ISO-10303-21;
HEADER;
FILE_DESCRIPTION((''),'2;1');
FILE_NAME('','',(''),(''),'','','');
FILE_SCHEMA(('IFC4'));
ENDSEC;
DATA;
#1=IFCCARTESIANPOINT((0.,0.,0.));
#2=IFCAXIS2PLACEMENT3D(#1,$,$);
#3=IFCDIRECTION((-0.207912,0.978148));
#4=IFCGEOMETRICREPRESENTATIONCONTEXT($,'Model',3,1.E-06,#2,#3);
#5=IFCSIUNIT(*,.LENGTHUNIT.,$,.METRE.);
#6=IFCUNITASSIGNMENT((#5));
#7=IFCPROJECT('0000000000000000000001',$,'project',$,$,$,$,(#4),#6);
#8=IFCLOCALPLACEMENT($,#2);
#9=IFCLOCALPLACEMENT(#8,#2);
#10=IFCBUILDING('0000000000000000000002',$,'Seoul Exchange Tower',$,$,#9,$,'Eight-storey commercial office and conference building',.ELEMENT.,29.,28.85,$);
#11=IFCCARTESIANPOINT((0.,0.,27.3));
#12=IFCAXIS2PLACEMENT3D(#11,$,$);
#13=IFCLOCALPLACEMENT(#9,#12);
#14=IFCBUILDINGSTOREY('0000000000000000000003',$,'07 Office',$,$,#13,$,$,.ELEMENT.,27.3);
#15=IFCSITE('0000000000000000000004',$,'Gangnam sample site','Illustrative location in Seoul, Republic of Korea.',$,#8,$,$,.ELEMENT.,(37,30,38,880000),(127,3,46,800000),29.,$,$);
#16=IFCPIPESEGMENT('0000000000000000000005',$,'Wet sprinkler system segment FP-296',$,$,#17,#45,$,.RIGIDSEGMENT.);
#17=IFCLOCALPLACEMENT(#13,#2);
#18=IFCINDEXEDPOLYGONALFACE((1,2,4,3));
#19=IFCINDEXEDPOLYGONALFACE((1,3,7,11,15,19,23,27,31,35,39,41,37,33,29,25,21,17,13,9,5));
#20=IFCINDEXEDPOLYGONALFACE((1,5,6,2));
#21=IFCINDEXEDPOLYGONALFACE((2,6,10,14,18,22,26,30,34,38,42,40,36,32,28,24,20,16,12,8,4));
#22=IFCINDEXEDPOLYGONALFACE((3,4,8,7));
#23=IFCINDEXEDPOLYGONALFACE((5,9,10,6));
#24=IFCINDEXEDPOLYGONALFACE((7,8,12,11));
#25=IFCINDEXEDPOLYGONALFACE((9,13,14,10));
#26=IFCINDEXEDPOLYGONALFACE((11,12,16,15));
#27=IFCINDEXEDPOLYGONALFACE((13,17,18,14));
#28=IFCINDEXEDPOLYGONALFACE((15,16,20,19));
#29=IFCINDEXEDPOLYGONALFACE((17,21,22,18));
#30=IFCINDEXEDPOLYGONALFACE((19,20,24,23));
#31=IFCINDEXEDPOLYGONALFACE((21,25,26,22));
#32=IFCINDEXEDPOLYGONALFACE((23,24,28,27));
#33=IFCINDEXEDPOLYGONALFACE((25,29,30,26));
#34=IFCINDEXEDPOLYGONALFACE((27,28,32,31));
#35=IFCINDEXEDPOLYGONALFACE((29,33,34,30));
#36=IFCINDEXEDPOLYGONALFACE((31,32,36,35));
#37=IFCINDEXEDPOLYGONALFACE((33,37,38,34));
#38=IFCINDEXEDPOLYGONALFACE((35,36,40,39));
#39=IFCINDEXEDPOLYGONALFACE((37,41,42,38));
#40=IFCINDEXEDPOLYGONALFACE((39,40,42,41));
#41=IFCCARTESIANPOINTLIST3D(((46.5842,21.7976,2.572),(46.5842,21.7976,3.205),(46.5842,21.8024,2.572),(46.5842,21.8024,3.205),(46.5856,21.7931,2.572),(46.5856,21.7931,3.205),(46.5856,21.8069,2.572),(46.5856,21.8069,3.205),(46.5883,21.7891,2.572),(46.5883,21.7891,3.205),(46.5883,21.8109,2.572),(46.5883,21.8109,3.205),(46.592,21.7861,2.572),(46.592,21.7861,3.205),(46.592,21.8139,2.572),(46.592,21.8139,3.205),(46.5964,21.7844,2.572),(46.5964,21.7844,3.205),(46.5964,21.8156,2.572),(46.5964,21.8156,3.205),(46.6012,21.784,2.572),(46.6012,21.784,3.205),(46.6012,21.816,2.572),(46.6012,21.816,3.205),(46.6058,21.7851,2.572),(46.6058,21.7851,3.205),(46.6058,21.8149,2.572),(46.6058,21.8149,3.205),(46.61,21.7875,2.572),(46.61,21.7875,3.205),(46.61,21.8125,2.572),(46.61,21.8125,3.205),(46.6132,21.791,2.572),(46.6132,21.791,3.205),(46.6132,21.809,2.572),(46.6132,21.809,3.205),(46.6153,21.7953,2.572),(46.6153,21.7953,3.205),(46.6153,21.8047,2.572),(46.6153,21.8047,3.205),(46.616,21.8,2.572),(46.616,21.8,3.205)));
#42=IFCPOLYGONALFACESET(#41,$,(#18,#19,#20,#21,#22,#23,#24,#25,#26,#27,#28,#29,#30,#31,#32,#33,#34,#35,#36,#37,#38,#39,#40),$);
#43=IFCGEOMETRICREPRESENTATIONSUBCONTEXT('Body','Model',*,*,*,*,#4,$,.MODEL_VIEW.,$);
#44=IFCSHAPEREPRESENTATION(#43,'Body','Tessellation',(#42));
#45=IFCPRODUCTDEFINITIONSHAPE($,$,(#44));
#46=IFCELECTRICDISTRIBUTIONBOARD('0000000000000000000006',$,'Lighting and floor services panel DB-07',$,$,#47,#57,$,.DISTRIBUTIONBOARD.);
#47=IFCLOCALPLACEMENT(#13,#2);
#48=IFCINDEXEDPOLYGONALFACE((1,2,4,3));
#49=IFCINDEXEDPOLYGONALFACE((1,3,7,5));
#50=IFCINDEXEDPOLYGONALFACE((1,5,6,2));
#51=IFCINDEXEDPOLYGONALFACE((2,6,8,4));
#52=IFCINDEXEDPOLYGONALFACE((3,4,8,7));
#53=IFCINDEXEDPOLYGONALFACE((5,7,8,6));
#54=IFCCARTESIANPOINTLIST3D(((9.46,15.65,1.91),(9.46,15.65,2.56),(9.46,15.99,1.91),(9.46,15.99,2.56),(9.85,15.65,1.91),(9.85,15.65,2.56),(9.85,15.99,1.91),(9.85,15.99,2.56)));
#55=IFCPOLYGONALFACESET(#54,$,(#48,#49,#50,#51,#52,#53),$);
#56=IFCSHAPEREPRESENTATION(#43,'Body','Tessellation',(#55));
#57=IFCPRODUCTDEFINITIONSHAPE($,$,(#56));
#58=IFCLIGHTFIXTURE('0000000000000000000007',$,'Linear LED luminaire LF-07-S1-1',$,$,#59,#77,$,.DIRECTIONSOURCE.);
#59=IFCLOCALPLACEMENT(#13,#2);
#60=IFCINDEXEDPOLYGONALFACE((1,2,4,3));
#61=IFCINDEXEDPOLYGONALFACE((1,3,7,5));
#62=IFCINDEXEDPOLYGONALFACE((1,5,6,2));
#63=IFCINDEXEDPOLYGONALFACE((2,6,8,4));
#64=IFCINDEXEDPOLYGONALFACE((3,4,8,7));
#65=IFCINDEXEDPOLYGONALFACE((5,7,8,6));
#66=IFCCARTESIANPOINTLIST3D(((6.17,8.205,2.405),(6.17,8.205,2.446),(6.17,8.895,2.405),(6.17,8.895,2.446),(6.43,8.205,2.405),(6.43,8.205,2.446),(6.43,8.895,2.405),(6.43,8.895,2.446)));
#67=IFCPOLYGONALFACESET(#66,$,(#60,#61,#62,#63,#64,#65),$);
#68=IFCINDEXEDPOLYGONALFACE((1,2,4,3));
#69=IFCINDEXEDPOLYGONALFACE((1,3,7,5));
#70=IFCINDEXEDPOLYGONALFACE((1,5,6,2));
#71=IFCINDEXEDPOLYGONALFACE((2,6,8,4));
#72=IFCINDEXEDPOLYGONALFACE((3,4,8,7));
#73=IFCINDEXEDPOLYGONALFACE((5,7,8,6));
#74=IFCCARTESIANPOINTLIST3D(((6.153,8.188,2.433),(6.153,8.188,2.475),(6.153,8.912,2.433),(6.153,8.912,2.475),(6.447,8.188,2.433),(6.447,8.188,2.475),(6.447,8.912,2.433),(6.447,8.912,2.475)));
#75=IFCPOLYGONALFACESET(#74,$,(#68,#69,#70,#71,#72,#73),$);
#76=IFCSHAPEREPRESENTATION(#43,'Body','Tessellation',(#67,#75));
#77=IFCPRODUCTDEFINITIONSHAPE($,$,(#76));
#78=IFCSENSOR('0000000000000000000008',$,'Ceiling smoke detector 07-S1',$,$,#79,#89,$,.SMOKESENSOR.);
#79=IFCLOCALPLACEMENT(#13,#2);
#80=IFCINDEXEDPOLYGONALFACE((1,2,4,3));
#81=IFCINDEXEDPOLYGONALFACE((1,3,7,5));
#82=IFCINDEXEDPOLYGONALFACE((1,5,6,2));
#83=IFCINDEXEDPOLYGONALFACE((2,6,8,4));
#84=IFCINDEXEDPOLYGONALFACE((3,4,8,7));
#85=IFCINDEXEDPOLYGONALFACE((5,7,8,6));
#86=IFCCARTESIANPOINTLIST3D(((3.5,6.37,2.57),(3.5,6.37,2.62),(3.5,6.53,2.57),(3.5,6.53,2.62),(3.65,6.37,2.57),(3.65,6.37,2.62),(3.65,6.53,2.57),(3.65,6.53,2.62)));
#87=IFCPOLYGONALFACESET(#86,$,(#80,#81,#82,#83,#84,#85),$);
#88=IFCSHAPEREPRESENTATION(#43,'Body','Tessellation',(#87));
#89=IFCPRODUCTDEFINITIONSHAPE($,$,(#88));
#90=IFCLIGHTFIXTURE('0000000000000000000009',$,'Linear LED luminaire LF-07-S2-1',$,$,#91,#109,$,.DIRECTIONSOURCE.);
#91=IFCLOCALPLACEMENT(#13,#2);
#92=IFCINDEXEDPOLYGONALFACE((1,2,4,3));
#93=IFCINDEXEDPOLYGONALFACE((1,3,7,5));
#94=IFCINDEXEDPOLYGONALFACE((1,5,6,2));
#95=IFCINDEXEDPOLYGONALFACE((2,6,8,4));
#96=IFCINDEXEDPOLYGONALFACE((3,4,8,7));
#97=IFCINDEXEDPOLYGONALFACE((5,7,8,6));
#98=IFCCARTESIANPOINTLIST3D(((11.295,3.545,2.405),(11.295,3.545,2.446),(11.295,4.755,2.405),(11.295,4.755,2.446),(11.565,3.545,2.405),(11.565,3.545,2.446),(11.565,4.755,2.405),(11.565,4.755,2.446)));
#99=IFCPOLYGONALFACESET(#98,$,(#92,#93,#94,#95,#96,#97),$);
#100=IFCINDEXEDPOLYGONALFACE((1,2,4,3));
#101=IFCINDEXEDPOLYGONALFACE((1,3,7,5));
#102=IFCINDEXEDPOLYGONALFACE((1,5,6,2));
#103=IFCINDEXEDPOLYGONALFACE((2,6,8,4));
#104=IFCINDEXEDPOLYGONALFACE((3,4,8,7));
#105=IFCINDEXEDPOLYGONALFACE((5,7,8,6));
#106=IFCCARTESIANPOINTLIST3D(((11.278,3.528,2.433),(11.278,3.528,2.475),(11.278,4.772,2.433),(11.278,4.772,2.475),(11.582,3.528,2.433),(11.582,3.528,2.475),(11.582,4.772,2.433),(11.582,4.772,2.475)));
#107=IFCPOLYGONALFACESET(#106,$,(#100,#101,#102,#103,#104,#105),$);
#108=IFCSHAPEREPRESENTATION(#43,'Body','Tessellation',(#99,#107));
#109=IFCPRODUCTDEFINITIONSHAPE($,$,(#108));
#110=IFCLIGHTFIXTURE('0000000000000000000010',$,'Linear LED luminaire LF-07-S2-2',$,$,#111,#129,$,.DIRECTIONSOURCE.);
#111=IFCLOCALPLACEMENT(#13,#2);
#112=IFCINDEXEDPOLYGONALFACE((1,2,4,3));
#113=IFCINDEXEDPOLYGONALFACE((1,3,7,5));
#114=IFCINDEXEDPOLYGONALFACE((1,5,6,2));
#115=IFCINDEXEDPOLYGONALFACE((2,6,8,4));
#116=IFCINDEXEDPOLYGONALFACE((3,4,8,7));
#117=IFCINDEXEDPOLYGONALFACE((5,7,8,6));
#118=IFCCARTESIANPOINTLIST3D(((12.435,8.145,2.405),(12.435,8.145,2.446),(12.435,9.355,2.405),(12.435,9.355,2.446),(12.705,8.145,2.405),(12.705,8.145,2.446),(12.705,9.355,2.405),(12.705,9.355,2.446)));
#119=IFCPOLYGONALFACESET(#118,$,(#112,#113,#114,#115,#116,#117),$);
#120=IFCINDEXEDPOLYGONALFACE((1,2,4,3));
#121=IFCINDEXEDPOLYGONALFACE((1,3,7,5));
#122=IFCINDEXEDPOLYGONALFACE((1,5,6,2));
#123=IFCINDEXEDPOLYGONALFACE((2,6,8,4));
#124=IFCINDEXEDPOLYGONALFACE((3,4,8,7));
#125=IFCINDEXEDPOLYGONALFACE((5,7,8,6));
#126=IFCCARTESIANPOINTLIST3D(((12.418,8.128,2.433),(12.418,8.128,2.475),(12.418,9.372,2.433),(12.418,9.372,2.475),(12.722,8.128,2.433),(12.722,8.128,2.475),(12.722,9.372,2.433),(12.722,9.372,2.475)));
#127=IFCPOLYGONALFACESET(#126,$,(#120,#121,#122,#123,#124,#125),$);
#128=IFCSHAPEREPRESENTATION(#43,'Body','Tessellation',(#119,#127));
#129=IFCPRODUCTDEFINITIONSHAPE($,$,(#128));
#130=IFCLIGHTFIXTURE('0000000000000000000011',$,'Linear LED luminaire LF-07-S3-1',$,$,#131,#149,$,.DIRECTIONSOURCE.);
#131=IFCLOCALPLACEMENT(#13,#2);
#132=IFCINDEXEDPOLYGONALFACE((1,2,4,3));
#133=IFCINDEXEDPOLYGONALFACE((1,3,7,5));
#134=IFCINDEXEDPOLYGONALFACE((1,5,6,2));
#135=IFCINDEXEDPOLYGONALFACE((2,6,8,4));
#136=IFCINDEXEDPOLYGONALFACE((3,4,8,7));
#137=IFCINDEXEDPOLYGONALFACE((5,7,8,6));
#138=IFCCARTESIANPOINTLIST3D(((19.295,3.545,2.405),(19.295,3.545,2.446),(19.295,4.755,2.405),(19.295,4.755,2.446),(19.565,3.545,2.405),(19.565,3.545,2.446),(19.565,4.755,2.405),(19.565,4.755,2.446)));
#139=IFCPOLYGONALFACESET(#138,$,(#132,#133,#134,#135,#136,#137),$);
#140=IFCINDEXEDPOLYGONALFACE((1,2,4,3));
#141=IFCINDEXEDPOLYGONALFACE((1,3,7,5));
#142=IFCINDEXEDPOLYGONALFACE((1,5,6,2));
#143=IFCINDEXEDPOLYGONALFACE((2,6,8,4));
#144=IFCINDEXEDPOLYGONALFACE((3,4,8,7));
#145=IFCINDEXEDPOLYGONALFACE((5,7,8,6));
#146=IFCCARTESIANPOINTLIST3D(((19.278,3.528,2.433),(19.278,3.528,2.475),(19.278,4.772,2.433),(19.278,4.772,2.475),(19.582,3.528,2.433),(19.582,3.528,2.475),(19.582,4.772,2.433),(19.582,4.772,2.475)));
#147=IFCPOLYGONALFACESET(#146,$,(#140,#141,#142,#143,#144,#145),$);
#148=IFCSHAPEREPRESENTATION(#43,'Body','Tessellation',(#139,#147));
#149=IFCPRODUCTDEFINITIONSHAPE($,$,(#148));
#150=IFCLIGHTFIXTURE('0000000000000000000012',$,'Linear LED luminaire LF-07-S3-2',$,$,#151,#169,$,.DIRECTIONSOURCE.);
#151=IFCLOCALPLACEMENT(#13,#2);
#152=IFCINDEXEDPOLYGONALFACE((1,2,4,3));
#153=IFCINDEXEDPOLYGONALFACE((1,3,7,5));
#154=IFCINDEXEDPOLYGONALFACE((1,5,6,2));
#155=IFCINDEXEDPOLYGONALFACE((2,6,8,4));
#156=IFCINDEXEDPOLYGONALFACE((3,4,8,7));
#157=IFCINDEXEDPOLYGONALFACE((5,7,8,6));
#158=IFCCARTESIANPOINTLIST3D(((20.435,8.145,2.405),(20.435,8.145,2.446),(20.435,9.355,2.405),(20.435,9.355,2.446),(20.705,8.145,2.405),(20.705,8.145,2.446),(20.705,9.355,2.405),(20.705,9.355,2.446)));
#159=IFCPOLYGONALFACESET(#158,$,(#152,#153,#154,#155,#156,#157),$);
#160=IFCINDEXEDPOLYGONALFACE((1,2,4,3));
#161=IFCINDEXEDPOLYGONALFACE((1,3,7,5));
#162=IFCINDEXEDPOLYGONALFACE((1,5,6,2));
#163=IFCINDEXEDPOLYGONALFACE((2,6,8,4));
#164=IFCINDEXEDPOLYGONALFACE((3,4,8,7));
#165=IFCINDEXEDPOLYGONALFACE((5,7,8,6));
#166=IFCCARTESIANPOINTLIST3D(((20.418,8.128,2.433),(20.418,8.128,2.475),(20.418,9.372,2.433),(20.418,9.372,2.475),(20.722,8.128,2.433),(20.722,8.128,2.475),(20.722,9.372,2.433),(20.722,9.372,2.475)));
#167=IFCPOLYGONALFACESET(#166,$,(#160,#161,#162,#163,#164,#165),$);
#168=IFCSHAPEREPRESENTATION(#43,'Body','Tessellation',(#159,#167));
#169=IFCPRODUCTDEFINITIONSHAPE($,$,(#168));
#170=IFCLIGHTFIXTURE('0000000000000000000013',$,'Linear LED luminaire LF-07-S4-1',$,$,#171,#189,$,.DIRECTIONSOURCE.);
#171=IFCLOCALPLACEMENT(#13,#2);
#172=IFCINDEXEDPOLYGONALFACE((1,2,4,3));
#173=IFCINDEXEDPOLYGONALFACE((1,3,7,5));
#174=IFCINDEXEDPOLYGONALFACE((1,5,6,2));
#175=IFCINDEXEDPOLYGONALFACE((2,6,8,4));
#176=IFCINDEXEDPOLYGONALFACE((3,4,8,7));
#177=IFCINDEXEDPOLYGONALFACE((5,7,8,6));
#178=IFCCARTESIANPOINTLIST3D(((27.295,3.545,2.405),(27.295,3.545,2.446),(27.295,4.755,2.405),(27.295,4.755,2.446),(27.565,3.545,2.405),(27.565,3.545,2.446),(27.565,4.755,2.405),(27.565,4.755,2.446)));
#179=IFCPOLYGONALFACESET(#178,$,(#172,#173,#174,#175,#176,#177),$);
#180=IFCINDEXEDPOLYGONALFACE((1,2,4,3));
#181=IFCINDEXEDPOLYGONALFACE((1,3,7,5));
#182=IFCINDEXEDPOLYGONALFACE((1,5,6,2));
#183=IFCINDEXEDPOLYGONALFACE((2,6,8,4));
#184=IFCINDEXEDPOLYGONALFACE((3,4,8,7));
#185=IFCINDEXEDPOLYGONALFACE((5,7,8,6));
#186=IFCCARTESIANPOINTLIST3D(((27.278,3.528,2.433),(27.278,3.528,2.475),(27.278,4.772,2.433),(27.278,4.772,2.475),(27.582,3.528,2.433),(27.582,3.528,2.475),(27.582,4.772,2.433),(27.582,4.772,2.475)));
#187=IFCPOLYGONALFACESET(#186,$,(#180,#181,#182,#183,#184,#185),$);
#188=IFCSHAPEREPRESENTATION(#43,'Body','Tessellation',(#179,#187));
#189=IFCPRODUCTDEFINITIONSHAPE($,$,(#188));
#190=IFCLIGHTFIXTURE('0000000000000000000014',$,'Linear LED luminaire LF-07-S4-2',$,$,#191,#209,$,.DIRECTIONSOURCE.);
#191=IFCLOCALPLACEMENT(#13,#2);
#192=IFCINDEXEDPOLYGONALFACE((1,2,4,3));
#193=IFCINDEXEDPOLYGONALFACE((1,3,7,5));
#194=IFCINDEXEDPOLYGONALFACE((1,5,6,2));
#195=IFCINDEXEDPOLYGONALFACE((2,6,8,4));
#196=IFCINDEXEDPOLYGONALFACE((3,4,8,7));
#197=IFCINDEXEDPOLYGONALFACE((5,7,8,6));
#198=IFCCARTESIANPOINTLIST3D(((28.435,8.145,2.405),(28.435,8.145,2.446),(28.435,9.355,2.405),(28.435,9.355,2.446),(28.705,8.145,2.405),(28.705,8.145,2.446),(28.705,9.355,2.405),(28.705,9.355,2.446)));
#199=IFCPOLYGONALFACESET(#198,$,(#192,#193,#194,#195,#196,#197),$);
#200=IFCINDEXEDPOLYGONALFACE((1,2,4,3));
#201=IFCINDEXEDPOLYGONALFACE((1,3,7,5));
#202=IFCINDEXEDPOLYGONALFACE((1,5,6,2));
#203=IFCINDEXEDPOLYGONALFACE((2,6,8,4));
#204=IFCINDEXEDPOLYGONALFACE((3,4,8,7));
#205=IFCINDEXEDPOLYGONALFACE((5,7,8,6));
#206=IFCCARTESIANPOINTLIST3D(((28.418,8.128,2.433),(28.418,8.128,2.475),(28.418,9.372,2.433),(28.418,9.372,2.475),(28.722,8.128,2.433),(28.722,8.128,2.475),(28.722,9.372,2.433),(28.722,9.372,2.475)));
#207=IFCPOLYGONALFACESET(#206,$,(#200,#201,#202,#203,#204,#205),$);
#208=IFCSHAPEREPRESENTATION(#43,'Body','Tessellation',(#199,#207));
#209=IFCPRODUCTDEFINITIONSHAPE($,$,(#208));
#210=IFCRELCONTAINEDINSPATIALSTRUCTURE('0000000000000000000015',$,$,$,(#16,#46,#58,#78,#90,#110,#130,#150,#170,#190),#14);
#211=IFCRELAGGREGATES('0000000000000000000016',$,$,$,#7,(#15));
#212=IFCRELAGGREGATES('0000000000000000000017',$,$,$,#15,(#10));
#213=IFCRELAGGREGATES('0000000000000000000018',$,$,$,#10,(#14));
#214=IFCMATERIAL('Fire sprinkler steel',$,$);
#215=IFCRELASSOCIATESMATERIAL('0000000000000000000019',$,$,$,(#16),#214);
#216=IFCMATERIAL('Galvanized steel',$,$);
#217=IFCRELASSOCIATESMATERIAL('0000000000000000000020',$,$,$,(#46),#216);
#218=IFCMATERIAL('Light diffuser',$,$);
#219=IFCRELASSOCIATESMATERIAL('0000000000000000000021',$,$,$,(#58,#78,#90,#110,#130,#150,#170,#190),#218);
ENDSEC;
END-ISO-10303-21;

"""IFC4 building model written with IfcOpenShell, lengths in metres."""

from ifc_helpers import new_model, si_unit, direction, frame, frame_2d, origin, place, context, subcontext, project, spatial, rectangle, circle, extrude, material, element, save


model = new_model("IFC4")

# Units and contexts
model_context = context("Model", 3, precision=1e-06, world=origin(), true_north=direction((-0.207912, 0.978148)))
body_context = subcontext(model_context, "Body", "Model", "MODEL_VIEW")
ifc_project = project(units=[si_unit("LENGTHUNIT", "METRE")], contexts=[model_context])

# Site, building, storey
site_placement = place(None, origin())
site = spatial("IfcSite", under=ifc_project, at=site_placement, Name="Gangnam sample site", Description="Illustrative location in Seoul, Republic of Korea.", CompositionType="ELEMENT", RefLatitude=(37, 30, 38, 880000), RefLongitude=(127, 3, 46, 800000), RefElevation=29.0)
building_placement = place(site_placement, origin())
building = spatial("IfcBuilding", under=site, at=building_placement, Name="Seoul Exchange Tower", LongName="Eight-storey commercial office and conference building", CompositionType="ELEMENT", ElevationOfRefHeight=29.0, ElevationOfTerrain=28.85)
storey_placement = place(building_placement, frame((0.0, 0.0, 27.3)))
storey = spatial("IfcBuildingStorey", under=building, at=storey_placement, Name="07 Office", CompositionType="ELEMENT", Elevation=27.3)

# Pipe segment
ifc_material_1 = material(Name="Fire sprinkler steel")
placement = place(storey_placement, origin())
element("IfcPipeSegment", 1, at=placement, inside=storey, material=ifc_material_1, Name="Wet sprinkler system segment FP-296", PredefinedType="RIGIDSEGMENT", context=body_context, shape_type="SweptSolid", body=[
    extrude(circle(Radius=0.016), frame((46.6, 21.8, 3.205), z_axis=(0.0, 0.0, -1.0), x_axis=(1.0, 0.0, 0.0)), (0.0, 0.0, 1.0), 0.633),
])

# Electric distribution board
ifc_material_2 = material(Name="Galvanized steel")
element("IfcElectricDistributionBoard", 2, at=placement, inside=storey, material=ifc_material_2, Name="Lighting and floor services panel DB-07", PredefinedType="DISTRIBUTIONBOARD", context=body_context, shape_type="SweptSolid", body=[
    extrude(rectangle(XDim=0.39, YDim=0.34, at=frame_2d((0.195, 0.17))), frame((9.46, 15.65, 1.91)), (0.0, 0.0, 1.0), 0.65),
])

# Light fixture
ifc_material_3 = material(Name="Light diffuser")
element("IfcLightFixture", 3, at=placement, inside=storey, material=ifc_material_3, Name="Linear LED luminaire LF-07-S1-1", PredefinedType="DIRECTIONSOURCE", context=body_context, shape_type="SweptSolid", body=[
    extrude(rectangle(XDim=0.26, YDim=0.69, at=frame_2d((0.13, 0.345))), frame((6.17, 8.205, 2.405)), (0.0, 0.0, 1.0), 0.041),
    extrude(rectangle(XDim=0.294, YDim=0.724, at=frame_2d((0.147, 0.362))), frame((6.153, 8.188, 2.433)), (0.0, 0.0, 1.0), 0.042),
])

# Sensor
element("IfcSensor", 4, at=placement, inside=storey, material=ifc_material_3, Name="Ceiling smoke detector 07-S1", PredefinedType="SMOKESENSOR", context=body_context, shape_type="SweptSolid", body=[
    extrude(rectangle(XDim=0.15, YDim=0.16, at=frame_2d((0.075, 0.08))), frame((3.5, 6.37, 2.57)), (0.0, 0.0, 1.0), 0.05),
])

# Light fixtures
element("IfcLightFixture", 5, at=placement, inside=storey, material=ifc_material_3, Name="Linear LED luminaire LF-07-S2-1", PredefinedType="DIRECTIONSOURCE", context=body_context, shape_type="SweptSolid", body=[
    extrude(rectangle(XDim=0.27, YDim=1.21, at=frame_2d((0.135, 0.605))), frame((11.295, 3.545, 2.405)), (0.0, 0.0, 1.0), 0.041),
    extrude(rectangle(XDim=0.304, YDim=1.244, at=frame_2d((0.152, 0.622))), frame((11.278, 3.528, 2.433)), (0.0, 0.0, 1.0), 0.042),
])
element("IfcLightFixture", 6, at=placement, inside=storey, material=ifc_material_3, Name="Linear LED luminaire LF-07-S2-2", PredefinedType="DIRECTIONSOURCE", context=body_context, shape_type="SweptSolid", body=[
    extrude(rectangle(XDim=0.27, YDim=1.21, at=frame_2d((0.135, 0.605))), frame((12.435, 8.145, 2.405)), (0.0, 0.0, 1.0), 0.041),
    extrude(rectangle(XDim=0.304, YDim=1.244, at=frame_2d((0.152, 0.622))), frame((12.418, 8.128, 2.433)), (0.0, 0.0, 1.0), 0.042),
])
element("IfcLightFixture", 7, at=placement, inside=storey, material=ifc_material_3, Name="Linear LED luminaire LF-07-S3-1", PredefinedType="DIRECTIONSOURCE", context=body_context, shape_type="SweptSolid", body=[
    extrude(rectangle(XDim=0.27, YDim=1.21, at=frame_2d((0.135, 0.605))), frame((19.295, 3.545, 2.405)), (0.0, 0.0, 1.0), 0.041),
    extrude(rectangle(XDim=0.304, YDim=1.244, at=frame_2d((0.152, 0.622))), frame((19.278, 3.528, 2.433)), (0.0, 0.0, 1.0), 0.042),
])
element("IfcLightFixture", 8, at=placement, inside=storey, material=ifc_material_3, Name="Linear LED luminaire LF-07-S3-2", PredefinedType="DIRECTIONSOURCE", context=body_context, shape_type="SweptSolid", body=[
    extrude(rectangle(XDim=0.27, YDim=1.21, at=frame_2d((0.135, 0.605))), frame((20.435, 8.145, 2.405)), (0.0, 0.0, 1.0), 0.041),
    extrude(rectangle(XDim=0.304, YDim=1.244, at=frame_2d((0.152, 0.622))), frame((20.418, 8.128, 2.433)), (0.0, 0.0, 1.0), 0.042),
])
element("IfcLightFixture", 9, at=placement, inside=storey, material=ifc_material_3, Name="Linear LED luminaire LF-07-S4-1", PredefinedType="DIRECTIONSOURCE", context=body_context, shape_type="SweptSolid", body=[
    extrude(rectangle(XDim=0.27, YDim=1.21, at=frame_2d((0.135, 0.605))), frame((27.295, 3.545, 2.405)), (0.0, 0.0, 1.0), 0.041),
    extrude(rectangle(XDim=0.304, YDim=1.244, at=frame_2d((0.152, 0.622))), frame((27.278, 3.528, 2.433)), (0.0, 0.0, 1.0), 0.042),
])
element("IfcLightFixture", 10, at=placement, inside=storey, material=ifc_material_3, Name="Linear LED luminaire LF-07-S4-2", PredefinedType="DIRECTIONSOURCE", context=body_context, shape_type="SweptSolid", body=[
    extrude(rectangle(XDim=0.27, YDim=1.21, at=frame_2d((0.135, 0.605))), frame((28.435, 8.145, 2.405)), (0.0, 0.0, 1.0), 0.041),
    extrude(rectangle(XDim=0.304, YDim=1.244, at=frame_2d((0.152, 0.622))), frame((28.418, 8.128, 2.433)), (0.0, 0.0, 1.0), 0.042),
])

save(model, "model.ifc")
